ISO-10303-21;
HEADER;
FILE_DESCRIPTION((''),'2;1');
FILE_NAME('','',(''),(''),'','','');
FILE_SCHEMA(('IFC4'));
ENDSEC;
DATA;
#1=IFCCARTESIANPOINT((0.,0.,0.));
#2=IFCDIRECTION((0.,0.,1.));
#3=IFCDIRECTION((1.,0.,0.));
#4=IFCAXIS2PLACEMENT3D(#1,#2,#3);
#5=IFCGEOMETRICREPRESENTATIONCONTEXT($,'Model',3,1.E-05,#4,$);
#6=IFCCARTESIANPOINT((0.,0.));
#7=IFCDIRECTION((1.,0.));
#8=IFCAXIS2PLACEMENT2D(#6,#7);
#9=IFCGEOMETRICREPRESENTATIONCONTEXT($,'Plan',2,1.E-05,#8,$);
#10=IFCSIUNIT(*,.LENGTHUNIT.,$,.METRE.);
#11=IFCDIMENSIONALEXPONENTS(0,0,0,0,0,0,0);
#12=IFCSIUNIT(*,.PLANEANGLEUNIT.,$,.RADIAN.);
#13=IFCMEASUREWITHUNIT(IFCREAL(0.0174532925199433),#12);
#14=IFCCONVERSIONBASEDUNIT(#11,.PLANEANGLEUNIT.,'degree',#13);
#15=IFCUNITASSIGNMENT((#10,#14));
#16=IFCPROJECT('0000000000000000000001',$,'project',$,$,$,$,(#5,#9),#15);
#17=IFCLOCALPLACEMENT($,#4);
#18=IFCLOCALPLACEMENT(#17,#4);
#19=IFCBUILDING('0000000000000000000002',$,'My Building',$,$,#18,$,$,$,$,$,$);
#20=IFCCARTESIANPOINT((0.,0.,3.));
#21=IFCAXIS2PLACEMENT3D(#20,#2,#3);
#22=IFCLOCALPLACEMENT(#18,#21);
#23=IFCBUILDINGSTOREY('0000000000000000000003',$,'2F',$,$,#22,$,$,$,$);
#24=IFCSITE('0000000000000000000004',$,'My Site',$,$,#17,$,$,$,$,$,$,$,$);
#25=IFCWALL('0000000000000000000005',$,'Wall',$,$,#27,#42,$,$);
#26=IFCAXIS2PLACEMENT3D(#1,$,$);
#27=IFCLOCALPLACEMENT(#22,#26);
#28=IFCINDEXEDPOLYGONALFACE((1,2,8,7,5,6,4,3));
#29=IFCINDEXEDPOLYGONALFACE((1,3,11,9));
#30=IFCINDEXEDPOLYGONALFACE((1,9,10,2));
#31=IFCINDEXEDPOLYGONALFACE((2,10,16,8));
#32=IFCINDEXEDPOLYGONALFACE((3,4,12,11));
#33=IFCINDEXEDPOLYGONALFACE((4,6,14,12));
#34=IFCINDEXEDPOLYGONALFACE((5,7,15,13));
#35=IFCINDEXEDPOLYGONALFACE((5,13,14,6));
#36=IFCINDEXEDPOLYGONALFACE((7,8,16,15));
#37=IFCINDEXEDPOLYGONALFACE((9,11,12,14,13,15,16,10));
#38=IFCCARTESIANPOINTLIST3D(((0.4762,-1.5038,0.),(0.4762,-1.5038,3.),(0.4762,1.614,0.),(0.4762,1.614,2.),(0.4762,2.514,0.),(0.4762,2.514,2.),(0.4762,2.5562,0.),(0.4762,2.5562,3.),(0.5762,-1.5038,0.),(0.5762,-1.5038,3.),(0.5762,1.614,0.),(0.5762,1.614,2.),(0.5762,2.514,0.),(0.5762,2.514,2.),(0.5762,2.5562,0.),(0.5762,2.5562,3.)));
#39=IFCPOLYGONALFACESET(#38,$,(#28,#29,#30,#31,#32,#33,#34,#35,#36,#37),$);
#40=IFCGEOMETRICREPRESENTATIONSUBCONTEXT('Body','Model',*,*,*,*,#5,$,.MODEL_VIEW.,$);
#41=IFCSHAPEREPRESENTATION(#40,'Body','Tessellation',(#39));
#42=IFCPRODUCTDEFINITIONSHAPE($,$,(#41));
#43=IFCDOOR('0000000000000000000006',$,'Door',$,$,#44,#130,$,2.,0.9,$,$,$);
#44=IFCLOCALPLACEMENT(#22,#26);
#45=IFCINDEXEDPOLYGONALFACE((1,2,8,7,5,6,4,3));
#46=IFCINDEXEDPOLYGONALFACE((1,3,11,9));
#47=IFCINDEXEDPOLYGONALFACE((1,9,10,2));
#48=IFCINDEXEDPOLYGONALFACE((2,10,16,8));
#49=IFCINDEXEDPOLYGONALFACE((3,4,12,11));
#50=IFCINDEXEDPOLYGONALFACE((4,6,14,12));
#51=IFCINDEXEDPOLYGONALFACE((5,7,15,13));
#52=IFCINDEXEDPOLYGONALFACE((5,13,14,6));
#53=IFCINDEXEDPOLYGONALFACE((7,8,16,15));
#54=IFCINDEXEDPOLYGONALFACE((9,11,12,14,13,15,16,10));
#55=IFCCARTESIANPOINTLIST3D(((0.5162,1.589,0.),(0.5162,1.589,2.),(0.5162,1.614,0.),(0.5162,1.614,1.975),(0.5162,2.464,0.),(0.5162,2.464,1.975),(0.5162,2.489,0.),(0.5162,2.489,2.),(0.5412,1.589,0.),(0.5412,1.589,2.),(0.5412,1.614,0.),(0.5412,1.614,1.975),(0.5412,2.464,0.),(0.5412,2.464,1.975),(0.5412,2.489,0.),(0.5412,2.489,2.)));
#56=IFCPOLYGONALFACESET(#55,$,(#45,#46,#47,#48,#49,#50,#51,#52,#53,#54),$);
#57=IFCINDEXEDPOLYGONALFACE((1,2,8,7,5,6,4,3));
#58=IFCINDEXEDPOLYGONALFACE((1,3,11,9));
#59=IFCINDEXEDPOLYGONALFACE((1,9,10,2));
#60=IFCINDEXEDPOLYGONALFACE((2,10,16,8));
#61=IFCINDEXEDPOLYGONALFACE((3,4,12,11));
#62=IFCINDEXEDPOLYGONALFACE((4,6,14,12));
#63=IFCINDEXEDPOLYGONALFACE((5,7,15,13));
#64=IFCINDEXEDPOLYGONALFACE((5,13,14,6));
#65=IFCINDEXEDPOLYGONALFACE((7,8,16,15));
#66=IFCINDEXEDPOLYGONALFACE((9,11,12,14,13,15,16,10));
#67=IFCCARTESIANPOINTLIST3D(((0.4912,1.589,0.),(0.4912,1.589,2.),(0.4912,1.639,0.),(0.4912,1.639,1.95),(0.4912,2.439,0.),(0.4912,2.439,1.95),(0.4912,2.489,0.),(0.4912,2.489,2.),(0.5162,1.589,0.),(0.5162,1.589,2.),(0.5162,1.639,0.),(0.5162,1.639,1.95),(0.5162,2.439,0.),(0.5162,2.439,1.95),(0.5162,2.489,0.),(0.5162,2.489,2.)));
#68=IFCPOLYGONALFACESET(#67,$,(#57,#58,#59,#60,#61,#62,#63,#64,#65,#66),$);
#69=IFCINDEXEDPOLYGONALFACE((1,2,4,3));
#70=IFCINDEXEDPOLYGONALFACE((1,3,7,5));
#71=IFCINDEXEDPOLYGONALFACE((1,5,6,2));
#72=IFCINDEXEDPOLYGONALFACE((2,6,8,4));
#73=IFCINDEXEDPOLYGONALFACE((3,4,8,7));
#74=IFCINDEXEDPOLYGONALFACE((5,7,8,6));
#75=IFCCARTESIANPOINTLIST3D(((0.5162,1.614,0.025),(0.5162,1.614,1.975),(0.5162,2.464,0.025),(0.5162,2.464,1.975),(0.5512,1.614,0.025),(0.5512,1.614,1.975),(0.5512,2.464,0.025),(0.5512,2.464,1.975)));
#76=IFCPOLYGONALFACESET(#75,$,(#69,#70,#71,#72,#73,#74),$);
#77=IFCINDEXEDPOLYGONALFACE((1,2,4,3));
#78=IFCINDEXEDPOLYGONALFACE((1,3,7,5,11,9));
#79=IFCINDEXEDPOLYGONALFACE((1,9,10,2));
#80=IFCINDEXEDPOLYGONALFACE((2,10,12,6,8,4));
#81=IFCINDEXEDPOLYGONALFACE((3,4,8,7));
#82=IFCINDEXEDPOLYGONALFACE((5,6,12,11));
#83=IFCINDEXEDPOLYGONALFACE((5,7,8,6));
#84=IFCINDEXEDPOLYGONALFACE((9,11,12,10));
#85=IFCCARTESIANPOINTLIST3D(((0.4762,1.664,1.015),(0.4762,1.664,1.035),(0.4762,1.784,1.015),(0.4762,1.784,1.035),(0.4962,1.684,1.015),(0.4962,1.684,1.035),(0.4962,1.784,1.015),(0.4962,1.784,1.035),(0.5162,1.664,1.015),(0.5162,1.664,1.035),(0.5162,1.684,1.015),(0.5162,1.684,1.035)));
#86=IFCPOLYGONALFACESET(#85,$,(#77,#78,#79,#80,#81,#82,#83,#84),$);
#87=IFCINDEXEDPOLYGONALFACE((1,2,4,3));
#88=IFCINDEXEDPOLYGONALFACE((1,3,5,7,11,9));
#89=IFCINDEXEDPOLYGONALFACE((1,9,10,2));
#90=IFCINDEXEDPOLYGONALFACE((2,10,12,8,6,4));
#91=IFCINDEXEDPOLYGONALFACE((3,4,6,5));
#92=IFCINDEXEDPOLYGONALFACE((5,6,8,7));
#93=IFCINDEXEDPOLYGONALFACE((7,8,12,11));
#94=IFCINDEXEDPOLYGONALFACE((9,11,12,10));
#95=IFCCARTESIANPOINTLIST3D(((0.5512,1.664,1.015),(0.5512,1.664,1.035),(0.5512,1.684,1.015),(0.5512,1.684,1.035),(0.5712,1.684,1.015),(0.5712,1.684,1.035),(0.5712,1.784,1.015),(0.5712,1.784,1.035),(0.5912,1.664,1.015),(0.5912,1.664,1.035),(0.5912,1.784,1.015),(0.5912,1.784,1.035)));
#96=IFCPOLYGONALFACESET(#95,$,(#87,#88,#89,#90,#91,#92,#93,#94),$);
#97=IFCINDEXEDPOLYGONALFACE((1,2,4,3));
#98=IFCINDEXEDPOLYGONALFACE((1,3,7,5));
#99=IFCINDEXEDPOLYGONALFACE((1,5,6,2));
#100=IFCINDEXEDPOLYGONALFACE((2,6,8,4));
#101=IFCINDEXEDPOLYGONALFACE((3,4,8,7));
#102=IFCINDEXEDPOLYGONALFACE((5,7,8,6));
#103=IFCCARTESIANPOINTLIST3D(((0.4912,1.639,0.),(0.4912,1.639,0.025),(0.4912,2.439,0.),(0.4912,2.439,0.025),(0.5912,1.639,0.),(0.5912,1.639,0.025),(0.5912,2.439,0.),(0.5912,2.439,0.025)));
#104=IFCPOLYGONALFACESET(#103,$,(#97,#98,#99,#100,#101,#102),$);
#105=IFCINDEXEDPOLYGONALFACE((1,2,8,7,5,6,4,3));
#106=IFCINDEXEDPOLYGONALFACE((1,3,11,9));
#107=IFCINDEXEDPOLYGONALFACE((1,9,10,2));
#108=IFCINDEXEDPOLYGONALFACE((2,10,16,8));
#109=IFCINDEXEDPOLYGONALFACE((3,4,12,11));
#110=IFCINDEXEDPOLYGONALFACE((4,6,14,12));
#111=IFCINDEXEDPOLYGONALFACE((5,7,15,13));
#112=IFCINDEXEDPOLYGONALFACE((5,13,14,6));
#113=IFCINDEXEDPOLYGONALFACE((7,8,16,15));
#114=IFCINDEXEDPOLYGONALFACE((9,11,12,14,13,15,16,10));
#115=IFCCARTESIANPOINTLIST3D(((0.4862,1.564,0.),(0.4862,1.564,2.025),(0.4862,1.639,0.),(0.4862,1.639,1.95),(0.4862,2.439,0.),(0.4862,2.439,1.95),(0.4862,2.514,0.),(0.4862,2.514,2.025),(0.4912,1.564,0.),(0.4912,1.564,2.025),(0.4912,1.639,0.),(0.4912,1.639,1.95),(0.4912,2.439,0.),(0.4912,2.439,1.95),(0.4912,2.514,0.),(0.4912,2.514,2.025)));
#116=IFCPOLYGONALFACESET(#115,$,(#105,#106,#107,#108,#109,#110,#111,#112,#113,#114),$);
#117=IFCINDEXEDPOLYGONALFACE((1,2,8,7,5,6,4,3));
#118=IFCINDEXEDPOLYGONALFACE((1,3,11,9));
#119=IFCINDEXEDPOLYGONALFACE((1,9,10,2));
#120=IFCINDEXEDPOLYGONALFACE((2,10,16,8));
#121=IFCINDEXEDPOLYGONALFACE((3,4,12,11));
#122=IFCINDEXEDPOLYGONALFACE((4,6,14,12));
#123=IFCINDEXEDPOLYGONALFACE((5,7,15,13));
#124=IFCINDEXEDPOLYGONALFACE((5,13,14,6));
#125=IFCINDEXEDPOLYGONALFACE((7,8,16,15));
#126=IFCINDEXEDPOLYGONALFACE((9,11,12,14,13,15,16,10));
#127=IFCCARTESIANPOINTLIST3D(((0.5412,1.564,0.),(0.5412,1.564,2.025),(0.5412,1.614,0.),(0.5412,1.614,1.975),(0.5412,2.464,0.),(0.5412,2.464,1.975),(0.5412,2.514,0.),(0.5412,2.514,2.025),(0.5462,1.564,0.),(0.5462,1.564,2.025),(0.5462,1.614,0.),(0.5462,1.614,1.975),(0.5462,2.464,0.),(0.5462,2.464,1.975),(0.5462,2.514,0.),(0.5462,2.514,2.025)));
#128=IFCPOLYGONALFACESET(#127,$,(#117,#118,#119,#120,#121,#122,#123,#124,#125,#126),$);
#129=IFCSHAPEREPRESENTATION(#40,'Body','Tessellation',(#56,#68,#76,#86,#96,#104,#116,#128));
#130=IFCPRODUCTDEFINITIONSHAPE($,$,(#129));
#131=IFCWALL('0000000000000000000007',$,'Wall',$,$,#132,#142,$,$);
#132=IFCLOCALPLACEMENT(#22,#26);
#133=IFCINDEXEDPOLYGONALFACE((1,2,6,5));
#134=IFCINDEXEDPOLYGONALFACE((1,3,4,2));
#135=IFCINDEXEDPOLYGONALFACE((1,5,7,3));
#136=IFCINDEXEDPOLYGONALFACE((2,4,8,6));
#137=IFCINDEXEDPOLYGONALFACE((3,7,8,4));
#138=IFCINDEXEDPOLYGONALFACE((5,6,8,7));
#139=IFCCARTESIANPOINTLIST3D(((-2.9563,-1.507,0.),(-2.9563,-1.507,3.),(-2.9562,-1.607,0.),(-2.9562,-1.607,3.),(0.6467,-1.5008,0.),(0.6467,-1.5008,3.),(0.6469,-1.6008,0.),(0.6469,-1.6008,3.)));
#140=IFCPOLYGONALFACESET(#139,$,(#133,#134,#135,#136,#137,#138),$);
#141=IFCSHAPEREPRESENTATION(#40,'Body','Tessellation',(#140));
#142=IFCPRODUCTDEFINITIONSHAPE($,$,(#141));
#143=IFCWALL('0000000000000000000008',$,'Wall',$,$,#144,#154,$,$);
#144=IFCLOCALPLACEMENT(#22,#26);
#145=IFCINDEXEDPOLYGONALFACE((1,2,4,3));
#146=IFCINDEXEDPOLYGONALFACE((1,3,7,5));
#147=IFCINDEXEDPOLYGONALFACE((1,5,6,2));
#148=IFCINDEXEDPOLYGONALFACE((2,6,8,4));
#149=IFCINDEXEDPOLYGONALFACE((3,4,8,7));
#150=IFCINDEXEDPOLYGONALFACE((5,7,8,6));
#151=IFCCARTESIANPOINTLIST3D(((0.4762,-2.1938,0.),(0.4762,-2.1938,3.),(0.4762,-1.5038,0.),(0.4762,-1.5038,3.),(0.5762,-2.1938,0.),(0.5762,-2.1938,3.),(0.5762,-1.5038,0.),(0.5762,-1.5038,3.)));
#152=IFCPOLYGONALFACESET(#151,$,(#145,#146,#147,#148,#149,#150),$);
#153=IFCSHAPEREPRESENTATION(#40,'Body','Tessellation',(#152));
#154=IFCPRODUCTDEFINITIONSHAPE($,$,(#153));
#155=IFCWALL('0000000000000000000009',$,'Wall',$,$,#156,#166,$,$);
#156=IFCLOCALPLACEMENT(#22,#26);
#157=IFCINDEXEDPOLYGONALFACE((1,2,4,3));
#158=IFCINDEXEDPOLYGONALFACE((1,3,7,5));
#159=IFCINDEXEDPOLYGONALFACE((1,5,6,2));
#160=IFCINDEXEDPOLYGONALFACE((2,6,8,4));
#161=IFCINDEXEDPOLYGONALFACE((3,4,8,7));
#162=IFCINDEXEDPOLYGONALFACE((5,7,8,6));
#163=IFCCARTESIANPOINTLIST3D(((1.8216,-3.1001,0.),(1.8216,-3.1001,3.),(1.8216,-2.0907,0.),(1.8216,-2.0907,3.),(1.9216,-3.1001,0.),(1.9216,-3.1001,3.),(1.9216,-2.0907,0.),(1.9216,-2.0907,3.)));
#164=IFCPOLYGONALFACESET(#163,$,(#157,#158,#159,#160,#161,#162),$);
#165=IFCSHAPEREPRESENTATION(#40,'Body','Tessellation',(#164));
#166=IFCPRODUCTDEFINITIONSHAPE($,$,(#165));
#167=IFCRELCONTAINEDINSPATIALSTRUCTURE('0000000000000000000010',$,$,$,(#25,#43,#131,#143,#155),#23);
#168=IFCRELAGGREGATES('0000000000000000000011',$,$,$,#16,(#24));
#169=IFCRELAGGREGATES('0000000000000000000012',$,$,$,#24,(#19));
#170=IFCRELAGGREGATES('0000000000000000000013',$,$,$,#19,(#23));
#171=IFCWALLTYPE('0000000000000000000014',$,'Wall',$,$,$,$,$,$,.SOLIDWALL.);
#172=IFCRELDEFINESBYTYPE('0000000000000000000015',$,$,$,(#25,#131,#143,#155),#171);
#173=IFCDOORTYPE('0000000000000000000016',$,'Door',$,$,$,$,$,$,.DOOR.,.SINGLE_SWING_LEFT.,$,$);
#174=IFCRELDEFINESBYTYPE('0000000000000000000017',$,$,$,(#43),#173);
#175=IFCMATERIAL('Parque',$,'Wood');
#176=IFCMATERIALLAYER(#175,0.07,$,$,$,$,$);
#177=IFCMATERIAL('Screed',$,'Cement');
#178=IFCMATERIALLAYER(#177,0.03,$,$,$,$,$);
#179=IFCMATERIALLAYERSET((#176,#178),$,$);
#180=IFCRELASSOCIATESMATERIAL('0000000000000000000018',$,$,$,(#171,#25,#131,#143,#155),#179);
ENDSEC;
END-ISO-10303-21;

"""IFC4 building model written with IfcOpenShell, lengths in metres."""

from ifc_helpers import new_model, entity, si_unit, converted_unit, frame, origin_with_axes, origin_2d_with_axis, place, context, subcontext, project, spatial, line, indexed_curve, outline, extrude, shape, source, transform, mapped, material, layer, layer_set, layer_usage, type_object, type_shapes, element, fill, save


model = new_model("IFC4")

# Units and contexts
model_context = context("Model", 3, precision=1e-05, world=origin_with_axes())
plan_context = context("Plan", 2, precision=1e-05, world=origin_2d_with_axis())
body_context_1 = subcontext(model_context, "Body", "Model", "MODEL_VIEW")
body_context_2 = subcontext(plan_context, "Body", "Plan", "PLAN_VIEW")
ifc_project = project(units=[si_unit("LENGTHUNIT", "METRE"), converted_unit("PLANEANGLEUNIT", "degree", entity("IfcReal", 0.0174532925199433), si_unit("PLANEANGLEUNIT", "RADIAN"), dimensions=[0, 0, 0, 0, 0, 0, 0])], contexts=[model_context, plan_context])

# Site, building, storey
site_placement = place(None, origin_with_axes())
site = spatial("IfcSite", under=ifc_project, at=site_placement, Name="My Site")
building_placement = place(site_placement, origin_with_axes())
building = spatial("IfcBuilding", under=site, at=building_placement, Name="My Building")
storey_placement = place(building_placement, frame((0.0, 0.0, 3.0), z_axis=(0.0, 0.0, 1.0), x_axis=(1.0, 0.0, 0.0)))
storey = spatial("IfcBuildingStorey", under=building, at=storey_placement, Name="2F")

# Shared definitions
ifc_material_1 = material(Name="Parque", Category="Wood")
ifc_layer_1 = layer(ifc_material_1, 0.07)
ifc_material_2 = material(Name="Screed", Category="Cement")
ifc_layer_2 = layer(ifc_material_2, 0.03)
ifc_layer_set_1 = layer_set([ifc_layer_1, ifc_layer_2])
wall_type = type_object("IfcWallType", Name="Wall", PredefinedType="SOLIDWALL", material=ifc_layer_set_1)

# Wall, opening, door
ifc_layer_usage_1 = layer_usage(ifc_layer_set_1, "AXIS2", "POSITIVE", 0.0)
wall_1_placement = place(storey_placement, frame((0.5762, -1.5038, 0.0), z_axis=(0.0, 0.0, 1.0), x_axis=(0.0, 1.0, 0.0)))
wall_1 = element("IfcWall", 1, at=wall_1_placement, inside=storey, type_object=wall_type, material=ifc_layer_usage_1, Name="Wall", context=body_context_1, shape_type="SweptSolid", body=[
    extrude(outline(indexed_curve([(0.0, 0.0), (0.0, 0.1), (4.06, 0.1), (4.06, 0.0)], segments=[line(1, 2, 3, 4, 1)])), origin_with_axes(), (0.0, 0.0, 1.0), 3.0),
])
shared_shape_1 = source(origin_with_axes(), body_context_1, "Body", "SweptSolid", [
    extrude(outline(indexed_curve([(0.0, 0.0), (0.9, 0.0), (0.9, 2.0), (0.0, 2.0)], segments=[line(1, 2, 3, 4, 1)])), frame((0.0, -0.6, 0.0), z_axis=(0.0, -1.0, 0.0), x_axis=(1.0, 0.0, 0.0)), (0.0, 0.0, -1.0), 1.2),
])
opening_1_placement = place(wall_1_placement, frame((3.1178, 0.0, 0.0), z_axis=(0.0, 0.0, 1.0), x_axis=(1.0, 0.0, 0.0)))
opening_1 = element("IfcOpeningElement", 2, at=opening_1_placement, cuts=wall_1, PredefinedType="OPENING", context=body_context_1, shape_type="MappedRepresentation", body=[
    mapped(shared_shape_1, transform((0.0, 0.0, 0.0), x_axis=(1.0, 0.0, 0.0), y_axis=(0.0, 1.0, 0.0), z_axis=(0.0, 0.0, 1.0), scale=1.0)),
])
door_type_1 = type_object("IfcDoorType", Name="Door", OperationType="SINGLE_SWING_LEFT", PredefinedType="DOOR")
shared_shape_2 = source(origin_with_axes(), body_context_1, "Body", "SweptSolid", [
    extrude(outline(indexed_curve([(0.0, 0.0), (0.0, 2.0), (0.9, 2.0), (0.9, 0.0), (0.875, 0.0), (0.875, 1.975), (0.025, 1.975), (0.025, 0.0)], segments=[line(1, 2, 3, 4, 5, 6, 7, 8, 1)])), frame((0.0, 0.025, 0.0), z_axis=(0.0, -1.0, 0.0), x_axis=(1.0, 0.0, 0.0)), (0.0, 0.0, -1.0), 0.025),
    extrude(outline(indexed_curve([(0.0, 0.0), (0.0, 2.0), (0.9, 2.0), (0.9, 0.0), (0.85, 0.0), (0.85, 1.95), (0.05, 1.95), (0.05, 0.0)], segments=[line(1, 2, 3, 4, 5, 6, 7, 8, 1)])), frame((0.0, 0.0, 0.0), z_axis=(0.0, -1.0, 0.0), x_axis=(1.0, 0.0, 0.0)), (0.0, 0.0, -1.0), 0.025),
    extrude(outline(indexed_curve([(0.0, 0.0), (0.85, 0.0), (0.85, 0.035), (0.0, 0.035)], segments=[line(1, 2, 3, 4, 1)])), frame((0.025, 0.025, 0.025), z_axis=(0.0, 0.0, 1.0), x_axis=(1.0, 0.0, 0.0)), (0.0, 0.0, 1.0), 1.95),
    extrude(outline(indexed_curve([(0.0, 0.0), (0.0, -0.04), (-0.12, -0.04), (-0.12, -0.02), (-0.02, -0.02), (-0.02, 0.0)], segments=[line(1, 2, 3, 4, 5, 6, 1)])), frame((0.825, 0.025, 1.015), z_axis=(0.0, 0.0, 1.0), x_axis=(1.0, 0.0, 0.0)), (0.0, 0.0, 1.0), 0.02),
    extrude(outline(indexed_curve([(0.0, 0.0), (0.0, 0.04), (-0.12, 0.04), (-0.12, 0.02), (-0.02, 0.02), (-0.02, 0.0)], segments=[line(1, 2, 3, 4, 5, 6, 1)])), frame((0.825, 0.06, 1.015), z_axis=(0.0, 0.0, 1.0), x_axis=(1.0, 0.0, 0.0)), (0.0, 0.0, 1.0), 0.02),
    extrude(outline(indexed_curve([(0.0, 0.0), (0.8, 0.0), (0.8, 0.1), (0.0, 0.1)], segments=[line(1, 2, 3, 4, 1)])), frame((0.05, 0.0, 0.0), z_axis=(0.0, 0.0, 1.0), x_axis=(1.0, 0.0, 0.0)), (0.0, 0.0, 1.0), 0.025),
    extrude(outline(indexed_curve([(0.0, 0.0), (0.0, 2.025), (0.95, 2.025), (0.95, 0.0), (0.875, 0.0), (0.875, 1.95), (0.075, 1.95), (0.075, 0.0)], segments=[line(1, 2, 3, 4, 5, 6, 7, 8, 1)])), frame((-0.025, -0.005, 0.0), z_axis=(0.0, -1.0, 0.0), x_axis=(1.0, 0.0, 0.0)), (0.0, 0.0, -1.0), 0.005),
    extrude(outline(indexed_curve([(0.0, 0.0), (0.0, 2.025), (0.95, 2.025), (0.95, 0.0), (0.9, 0.0), (0.9, 1.975), (0.05, 1.975), (0.05, 0.0)], segments=[line(1, 2, 3, 4, 5, 6, 7, 8, 1)])), frame((-0.025, 0.05, 0.0), z_axis=(0.0, -1.0, 0.0), x_axis=(1.0, 0.0, 0.0)), (0.0, 0.0, -1.0), 0.005),
])
shared_shape_3 = source(origin_with_axes(), body_context_2, "Body", "Curve2D", [
    entity("IfcIndexedPolyCurve", entity("IfcCartesianPointList2D", [[0.0, 0.0], [0.0, 0.05], [0.025, 0.05], [0.025, 0.025], [0.05, 0.025], [0.05, 0.0]]), [entity("IfcLineIndex", [1, 2, 3, 4, 5, 6, 1])]),
    entity("IfcIndexedPolyCurve", entity("IfcCartesianPointList2D", [[0.9, 0.0], [0.9, 0.05], [0.875, 0.05], [0.875, 0.025], [0.85, 0.025], [0.85, 0.0]]), [entity("IfcLineIndex", [1, 2, 3, 4, 5, 6, 1])]),
    entity("IfcTrimmedCurve", entity("IfcEllipse", entity("IfcAxis2Placement2D", entity("IfcCartesianPoint", [0.06, 0.05]), entity("IfcDirection", [1.0, 0.0])), 0.815, 0.85), [entity("IfcCartesianPoint", [0.875, 0.05])], [entity("IfcCartesianPoint", [0.06, 0.9])], True, "CARTESIAN"),
    entity("IfcIndexedPolyCurve", entity("IfcCartesianPointList2D", [[0.025, 0.05], [0.06, 0.05], [0.06, 0.9], [0.025, 0.9]]), [entity("IfcLineIndex", [1, 2, 3, 4, 1])]),
])
type_shapes(door_type_1, [shared_shape_2, shared_shape_3])
door_1_placement = place(opening_1_placement, frame((0.875, 0.085, 0.0), z_axis=(0.0, 0.0, 1.0), x_axis=(-1.0, -0.000001, 0.0)))
door_1 = element("IfcDoor", 3, at=door_1_placement, inside=storey, type_object=door_type_1, Name="Door", OverallHeight=2.0, OverallWidth=0.9, shapes=[
    shape(body_context_1, "Body", "MappedRepresentation", [mapped(shared_shape_2, transform((0.0, 0.0, 0.0), x_axis=(1.0, 0.0, 0.0), y_axis=(0.0, 1.0, 0.0), z_axis=(0.0, 0.0, 1.0), scale=1.0))]),
    shape(body_context_2, "Body", "MappedRepresentation", [mapped(shared_shape_3, transform((0.0, 0.0, 0.0), x_axis=(1.0, 0.0, 0.0), y_axis=(0.0, 1.0, 0.0), z_axis=(0.0, 0.0, 1.0), scale=1.0))]),
])
fill(opening_1, door_1)

# Walls
ifc_layer_usage_2 = layer_usage(ifc_layer_set_1, "AXIS2", "POSITIVE", 0.0)
wall_2_placement = place(storey_placement, frame((-2.9562, -1.607, 0.0), z_axis=(0.0, 0.0, 1.0), x_axis=(0.999999, 0.001712, 0.0)))
element("IfcWall", 4, at=wall_2_placement, inside=storey, type_object=wall_type, material=ifc_layer_usage_2, Name="Wall", context=body_context_1, shape_type="SweptSolid", body=[
    extrude(outline(indexed_curve([(0.0, 0.0), (0.0, 0.1), (3.6031, 0.1), (3.6031, 0.0)], segments=[line(1, 2, 3, 4, 1)])), origin_with_axes(), (0.0, 0.0, 1.0), 3.0),
])
ifc_layer_usage_3 = layer_usage(ifc_layer_set_1, "AXIS2", "POSITIVE", 0.0)
wall_3_placement = place(storey_placement, frame((0.4762, -1.5038, 0.0), z_axis=(0.0, 0.0, 1.0), x_axis=(0.0, -1.0, 0.0)))
element("IfcWall", 5, at=wall_3_placement, inside=storey, type_object=wall_type, material=ifc_layer_usage_3, Name="Wall", context=body_context_1, shape_type="SweptSolid", body=[
    extrude(outline(indexed_curve([(0.0, 0.0), (0.0, 0.1), (0.69, 0.1), (0.69, 0.0)], segments=[line(1, 2, 3, 4, 1)])), origin_with_axes(), (0.0, 0.0, 1.0), 3.0),
])
ifc_layer_usage_4 = layer_usage(ifc_layer_set_1, "AXIS2", "POSITIVE", 0.0)
wall_4_placement = place(storey_placement, frame((1.9216, -3.1001, 0.0), z_axis=(0.0, 0.0, 1.0), x_axis=(0.000002, 1.0, 0.0)))
element("IfcWall", 6, at=wall_4_placement, inside=storey, type_object=wall_type, material=ifc_layer_usage_4, Name="Wall", context=body_context_1, shape_type="SweptSolid", body=[
    extrude(outline(indexed_curve([(0.0, 0.0), (0.0, 0.1), (1.0094, 0.1), (1.0094, 0.0)], segments=[line(1, 2, 3, 4, 1)])), origin_with_axes(), (0.0, 0.0, 1.0), 3.0),
])

save(model, "model.ifc")
